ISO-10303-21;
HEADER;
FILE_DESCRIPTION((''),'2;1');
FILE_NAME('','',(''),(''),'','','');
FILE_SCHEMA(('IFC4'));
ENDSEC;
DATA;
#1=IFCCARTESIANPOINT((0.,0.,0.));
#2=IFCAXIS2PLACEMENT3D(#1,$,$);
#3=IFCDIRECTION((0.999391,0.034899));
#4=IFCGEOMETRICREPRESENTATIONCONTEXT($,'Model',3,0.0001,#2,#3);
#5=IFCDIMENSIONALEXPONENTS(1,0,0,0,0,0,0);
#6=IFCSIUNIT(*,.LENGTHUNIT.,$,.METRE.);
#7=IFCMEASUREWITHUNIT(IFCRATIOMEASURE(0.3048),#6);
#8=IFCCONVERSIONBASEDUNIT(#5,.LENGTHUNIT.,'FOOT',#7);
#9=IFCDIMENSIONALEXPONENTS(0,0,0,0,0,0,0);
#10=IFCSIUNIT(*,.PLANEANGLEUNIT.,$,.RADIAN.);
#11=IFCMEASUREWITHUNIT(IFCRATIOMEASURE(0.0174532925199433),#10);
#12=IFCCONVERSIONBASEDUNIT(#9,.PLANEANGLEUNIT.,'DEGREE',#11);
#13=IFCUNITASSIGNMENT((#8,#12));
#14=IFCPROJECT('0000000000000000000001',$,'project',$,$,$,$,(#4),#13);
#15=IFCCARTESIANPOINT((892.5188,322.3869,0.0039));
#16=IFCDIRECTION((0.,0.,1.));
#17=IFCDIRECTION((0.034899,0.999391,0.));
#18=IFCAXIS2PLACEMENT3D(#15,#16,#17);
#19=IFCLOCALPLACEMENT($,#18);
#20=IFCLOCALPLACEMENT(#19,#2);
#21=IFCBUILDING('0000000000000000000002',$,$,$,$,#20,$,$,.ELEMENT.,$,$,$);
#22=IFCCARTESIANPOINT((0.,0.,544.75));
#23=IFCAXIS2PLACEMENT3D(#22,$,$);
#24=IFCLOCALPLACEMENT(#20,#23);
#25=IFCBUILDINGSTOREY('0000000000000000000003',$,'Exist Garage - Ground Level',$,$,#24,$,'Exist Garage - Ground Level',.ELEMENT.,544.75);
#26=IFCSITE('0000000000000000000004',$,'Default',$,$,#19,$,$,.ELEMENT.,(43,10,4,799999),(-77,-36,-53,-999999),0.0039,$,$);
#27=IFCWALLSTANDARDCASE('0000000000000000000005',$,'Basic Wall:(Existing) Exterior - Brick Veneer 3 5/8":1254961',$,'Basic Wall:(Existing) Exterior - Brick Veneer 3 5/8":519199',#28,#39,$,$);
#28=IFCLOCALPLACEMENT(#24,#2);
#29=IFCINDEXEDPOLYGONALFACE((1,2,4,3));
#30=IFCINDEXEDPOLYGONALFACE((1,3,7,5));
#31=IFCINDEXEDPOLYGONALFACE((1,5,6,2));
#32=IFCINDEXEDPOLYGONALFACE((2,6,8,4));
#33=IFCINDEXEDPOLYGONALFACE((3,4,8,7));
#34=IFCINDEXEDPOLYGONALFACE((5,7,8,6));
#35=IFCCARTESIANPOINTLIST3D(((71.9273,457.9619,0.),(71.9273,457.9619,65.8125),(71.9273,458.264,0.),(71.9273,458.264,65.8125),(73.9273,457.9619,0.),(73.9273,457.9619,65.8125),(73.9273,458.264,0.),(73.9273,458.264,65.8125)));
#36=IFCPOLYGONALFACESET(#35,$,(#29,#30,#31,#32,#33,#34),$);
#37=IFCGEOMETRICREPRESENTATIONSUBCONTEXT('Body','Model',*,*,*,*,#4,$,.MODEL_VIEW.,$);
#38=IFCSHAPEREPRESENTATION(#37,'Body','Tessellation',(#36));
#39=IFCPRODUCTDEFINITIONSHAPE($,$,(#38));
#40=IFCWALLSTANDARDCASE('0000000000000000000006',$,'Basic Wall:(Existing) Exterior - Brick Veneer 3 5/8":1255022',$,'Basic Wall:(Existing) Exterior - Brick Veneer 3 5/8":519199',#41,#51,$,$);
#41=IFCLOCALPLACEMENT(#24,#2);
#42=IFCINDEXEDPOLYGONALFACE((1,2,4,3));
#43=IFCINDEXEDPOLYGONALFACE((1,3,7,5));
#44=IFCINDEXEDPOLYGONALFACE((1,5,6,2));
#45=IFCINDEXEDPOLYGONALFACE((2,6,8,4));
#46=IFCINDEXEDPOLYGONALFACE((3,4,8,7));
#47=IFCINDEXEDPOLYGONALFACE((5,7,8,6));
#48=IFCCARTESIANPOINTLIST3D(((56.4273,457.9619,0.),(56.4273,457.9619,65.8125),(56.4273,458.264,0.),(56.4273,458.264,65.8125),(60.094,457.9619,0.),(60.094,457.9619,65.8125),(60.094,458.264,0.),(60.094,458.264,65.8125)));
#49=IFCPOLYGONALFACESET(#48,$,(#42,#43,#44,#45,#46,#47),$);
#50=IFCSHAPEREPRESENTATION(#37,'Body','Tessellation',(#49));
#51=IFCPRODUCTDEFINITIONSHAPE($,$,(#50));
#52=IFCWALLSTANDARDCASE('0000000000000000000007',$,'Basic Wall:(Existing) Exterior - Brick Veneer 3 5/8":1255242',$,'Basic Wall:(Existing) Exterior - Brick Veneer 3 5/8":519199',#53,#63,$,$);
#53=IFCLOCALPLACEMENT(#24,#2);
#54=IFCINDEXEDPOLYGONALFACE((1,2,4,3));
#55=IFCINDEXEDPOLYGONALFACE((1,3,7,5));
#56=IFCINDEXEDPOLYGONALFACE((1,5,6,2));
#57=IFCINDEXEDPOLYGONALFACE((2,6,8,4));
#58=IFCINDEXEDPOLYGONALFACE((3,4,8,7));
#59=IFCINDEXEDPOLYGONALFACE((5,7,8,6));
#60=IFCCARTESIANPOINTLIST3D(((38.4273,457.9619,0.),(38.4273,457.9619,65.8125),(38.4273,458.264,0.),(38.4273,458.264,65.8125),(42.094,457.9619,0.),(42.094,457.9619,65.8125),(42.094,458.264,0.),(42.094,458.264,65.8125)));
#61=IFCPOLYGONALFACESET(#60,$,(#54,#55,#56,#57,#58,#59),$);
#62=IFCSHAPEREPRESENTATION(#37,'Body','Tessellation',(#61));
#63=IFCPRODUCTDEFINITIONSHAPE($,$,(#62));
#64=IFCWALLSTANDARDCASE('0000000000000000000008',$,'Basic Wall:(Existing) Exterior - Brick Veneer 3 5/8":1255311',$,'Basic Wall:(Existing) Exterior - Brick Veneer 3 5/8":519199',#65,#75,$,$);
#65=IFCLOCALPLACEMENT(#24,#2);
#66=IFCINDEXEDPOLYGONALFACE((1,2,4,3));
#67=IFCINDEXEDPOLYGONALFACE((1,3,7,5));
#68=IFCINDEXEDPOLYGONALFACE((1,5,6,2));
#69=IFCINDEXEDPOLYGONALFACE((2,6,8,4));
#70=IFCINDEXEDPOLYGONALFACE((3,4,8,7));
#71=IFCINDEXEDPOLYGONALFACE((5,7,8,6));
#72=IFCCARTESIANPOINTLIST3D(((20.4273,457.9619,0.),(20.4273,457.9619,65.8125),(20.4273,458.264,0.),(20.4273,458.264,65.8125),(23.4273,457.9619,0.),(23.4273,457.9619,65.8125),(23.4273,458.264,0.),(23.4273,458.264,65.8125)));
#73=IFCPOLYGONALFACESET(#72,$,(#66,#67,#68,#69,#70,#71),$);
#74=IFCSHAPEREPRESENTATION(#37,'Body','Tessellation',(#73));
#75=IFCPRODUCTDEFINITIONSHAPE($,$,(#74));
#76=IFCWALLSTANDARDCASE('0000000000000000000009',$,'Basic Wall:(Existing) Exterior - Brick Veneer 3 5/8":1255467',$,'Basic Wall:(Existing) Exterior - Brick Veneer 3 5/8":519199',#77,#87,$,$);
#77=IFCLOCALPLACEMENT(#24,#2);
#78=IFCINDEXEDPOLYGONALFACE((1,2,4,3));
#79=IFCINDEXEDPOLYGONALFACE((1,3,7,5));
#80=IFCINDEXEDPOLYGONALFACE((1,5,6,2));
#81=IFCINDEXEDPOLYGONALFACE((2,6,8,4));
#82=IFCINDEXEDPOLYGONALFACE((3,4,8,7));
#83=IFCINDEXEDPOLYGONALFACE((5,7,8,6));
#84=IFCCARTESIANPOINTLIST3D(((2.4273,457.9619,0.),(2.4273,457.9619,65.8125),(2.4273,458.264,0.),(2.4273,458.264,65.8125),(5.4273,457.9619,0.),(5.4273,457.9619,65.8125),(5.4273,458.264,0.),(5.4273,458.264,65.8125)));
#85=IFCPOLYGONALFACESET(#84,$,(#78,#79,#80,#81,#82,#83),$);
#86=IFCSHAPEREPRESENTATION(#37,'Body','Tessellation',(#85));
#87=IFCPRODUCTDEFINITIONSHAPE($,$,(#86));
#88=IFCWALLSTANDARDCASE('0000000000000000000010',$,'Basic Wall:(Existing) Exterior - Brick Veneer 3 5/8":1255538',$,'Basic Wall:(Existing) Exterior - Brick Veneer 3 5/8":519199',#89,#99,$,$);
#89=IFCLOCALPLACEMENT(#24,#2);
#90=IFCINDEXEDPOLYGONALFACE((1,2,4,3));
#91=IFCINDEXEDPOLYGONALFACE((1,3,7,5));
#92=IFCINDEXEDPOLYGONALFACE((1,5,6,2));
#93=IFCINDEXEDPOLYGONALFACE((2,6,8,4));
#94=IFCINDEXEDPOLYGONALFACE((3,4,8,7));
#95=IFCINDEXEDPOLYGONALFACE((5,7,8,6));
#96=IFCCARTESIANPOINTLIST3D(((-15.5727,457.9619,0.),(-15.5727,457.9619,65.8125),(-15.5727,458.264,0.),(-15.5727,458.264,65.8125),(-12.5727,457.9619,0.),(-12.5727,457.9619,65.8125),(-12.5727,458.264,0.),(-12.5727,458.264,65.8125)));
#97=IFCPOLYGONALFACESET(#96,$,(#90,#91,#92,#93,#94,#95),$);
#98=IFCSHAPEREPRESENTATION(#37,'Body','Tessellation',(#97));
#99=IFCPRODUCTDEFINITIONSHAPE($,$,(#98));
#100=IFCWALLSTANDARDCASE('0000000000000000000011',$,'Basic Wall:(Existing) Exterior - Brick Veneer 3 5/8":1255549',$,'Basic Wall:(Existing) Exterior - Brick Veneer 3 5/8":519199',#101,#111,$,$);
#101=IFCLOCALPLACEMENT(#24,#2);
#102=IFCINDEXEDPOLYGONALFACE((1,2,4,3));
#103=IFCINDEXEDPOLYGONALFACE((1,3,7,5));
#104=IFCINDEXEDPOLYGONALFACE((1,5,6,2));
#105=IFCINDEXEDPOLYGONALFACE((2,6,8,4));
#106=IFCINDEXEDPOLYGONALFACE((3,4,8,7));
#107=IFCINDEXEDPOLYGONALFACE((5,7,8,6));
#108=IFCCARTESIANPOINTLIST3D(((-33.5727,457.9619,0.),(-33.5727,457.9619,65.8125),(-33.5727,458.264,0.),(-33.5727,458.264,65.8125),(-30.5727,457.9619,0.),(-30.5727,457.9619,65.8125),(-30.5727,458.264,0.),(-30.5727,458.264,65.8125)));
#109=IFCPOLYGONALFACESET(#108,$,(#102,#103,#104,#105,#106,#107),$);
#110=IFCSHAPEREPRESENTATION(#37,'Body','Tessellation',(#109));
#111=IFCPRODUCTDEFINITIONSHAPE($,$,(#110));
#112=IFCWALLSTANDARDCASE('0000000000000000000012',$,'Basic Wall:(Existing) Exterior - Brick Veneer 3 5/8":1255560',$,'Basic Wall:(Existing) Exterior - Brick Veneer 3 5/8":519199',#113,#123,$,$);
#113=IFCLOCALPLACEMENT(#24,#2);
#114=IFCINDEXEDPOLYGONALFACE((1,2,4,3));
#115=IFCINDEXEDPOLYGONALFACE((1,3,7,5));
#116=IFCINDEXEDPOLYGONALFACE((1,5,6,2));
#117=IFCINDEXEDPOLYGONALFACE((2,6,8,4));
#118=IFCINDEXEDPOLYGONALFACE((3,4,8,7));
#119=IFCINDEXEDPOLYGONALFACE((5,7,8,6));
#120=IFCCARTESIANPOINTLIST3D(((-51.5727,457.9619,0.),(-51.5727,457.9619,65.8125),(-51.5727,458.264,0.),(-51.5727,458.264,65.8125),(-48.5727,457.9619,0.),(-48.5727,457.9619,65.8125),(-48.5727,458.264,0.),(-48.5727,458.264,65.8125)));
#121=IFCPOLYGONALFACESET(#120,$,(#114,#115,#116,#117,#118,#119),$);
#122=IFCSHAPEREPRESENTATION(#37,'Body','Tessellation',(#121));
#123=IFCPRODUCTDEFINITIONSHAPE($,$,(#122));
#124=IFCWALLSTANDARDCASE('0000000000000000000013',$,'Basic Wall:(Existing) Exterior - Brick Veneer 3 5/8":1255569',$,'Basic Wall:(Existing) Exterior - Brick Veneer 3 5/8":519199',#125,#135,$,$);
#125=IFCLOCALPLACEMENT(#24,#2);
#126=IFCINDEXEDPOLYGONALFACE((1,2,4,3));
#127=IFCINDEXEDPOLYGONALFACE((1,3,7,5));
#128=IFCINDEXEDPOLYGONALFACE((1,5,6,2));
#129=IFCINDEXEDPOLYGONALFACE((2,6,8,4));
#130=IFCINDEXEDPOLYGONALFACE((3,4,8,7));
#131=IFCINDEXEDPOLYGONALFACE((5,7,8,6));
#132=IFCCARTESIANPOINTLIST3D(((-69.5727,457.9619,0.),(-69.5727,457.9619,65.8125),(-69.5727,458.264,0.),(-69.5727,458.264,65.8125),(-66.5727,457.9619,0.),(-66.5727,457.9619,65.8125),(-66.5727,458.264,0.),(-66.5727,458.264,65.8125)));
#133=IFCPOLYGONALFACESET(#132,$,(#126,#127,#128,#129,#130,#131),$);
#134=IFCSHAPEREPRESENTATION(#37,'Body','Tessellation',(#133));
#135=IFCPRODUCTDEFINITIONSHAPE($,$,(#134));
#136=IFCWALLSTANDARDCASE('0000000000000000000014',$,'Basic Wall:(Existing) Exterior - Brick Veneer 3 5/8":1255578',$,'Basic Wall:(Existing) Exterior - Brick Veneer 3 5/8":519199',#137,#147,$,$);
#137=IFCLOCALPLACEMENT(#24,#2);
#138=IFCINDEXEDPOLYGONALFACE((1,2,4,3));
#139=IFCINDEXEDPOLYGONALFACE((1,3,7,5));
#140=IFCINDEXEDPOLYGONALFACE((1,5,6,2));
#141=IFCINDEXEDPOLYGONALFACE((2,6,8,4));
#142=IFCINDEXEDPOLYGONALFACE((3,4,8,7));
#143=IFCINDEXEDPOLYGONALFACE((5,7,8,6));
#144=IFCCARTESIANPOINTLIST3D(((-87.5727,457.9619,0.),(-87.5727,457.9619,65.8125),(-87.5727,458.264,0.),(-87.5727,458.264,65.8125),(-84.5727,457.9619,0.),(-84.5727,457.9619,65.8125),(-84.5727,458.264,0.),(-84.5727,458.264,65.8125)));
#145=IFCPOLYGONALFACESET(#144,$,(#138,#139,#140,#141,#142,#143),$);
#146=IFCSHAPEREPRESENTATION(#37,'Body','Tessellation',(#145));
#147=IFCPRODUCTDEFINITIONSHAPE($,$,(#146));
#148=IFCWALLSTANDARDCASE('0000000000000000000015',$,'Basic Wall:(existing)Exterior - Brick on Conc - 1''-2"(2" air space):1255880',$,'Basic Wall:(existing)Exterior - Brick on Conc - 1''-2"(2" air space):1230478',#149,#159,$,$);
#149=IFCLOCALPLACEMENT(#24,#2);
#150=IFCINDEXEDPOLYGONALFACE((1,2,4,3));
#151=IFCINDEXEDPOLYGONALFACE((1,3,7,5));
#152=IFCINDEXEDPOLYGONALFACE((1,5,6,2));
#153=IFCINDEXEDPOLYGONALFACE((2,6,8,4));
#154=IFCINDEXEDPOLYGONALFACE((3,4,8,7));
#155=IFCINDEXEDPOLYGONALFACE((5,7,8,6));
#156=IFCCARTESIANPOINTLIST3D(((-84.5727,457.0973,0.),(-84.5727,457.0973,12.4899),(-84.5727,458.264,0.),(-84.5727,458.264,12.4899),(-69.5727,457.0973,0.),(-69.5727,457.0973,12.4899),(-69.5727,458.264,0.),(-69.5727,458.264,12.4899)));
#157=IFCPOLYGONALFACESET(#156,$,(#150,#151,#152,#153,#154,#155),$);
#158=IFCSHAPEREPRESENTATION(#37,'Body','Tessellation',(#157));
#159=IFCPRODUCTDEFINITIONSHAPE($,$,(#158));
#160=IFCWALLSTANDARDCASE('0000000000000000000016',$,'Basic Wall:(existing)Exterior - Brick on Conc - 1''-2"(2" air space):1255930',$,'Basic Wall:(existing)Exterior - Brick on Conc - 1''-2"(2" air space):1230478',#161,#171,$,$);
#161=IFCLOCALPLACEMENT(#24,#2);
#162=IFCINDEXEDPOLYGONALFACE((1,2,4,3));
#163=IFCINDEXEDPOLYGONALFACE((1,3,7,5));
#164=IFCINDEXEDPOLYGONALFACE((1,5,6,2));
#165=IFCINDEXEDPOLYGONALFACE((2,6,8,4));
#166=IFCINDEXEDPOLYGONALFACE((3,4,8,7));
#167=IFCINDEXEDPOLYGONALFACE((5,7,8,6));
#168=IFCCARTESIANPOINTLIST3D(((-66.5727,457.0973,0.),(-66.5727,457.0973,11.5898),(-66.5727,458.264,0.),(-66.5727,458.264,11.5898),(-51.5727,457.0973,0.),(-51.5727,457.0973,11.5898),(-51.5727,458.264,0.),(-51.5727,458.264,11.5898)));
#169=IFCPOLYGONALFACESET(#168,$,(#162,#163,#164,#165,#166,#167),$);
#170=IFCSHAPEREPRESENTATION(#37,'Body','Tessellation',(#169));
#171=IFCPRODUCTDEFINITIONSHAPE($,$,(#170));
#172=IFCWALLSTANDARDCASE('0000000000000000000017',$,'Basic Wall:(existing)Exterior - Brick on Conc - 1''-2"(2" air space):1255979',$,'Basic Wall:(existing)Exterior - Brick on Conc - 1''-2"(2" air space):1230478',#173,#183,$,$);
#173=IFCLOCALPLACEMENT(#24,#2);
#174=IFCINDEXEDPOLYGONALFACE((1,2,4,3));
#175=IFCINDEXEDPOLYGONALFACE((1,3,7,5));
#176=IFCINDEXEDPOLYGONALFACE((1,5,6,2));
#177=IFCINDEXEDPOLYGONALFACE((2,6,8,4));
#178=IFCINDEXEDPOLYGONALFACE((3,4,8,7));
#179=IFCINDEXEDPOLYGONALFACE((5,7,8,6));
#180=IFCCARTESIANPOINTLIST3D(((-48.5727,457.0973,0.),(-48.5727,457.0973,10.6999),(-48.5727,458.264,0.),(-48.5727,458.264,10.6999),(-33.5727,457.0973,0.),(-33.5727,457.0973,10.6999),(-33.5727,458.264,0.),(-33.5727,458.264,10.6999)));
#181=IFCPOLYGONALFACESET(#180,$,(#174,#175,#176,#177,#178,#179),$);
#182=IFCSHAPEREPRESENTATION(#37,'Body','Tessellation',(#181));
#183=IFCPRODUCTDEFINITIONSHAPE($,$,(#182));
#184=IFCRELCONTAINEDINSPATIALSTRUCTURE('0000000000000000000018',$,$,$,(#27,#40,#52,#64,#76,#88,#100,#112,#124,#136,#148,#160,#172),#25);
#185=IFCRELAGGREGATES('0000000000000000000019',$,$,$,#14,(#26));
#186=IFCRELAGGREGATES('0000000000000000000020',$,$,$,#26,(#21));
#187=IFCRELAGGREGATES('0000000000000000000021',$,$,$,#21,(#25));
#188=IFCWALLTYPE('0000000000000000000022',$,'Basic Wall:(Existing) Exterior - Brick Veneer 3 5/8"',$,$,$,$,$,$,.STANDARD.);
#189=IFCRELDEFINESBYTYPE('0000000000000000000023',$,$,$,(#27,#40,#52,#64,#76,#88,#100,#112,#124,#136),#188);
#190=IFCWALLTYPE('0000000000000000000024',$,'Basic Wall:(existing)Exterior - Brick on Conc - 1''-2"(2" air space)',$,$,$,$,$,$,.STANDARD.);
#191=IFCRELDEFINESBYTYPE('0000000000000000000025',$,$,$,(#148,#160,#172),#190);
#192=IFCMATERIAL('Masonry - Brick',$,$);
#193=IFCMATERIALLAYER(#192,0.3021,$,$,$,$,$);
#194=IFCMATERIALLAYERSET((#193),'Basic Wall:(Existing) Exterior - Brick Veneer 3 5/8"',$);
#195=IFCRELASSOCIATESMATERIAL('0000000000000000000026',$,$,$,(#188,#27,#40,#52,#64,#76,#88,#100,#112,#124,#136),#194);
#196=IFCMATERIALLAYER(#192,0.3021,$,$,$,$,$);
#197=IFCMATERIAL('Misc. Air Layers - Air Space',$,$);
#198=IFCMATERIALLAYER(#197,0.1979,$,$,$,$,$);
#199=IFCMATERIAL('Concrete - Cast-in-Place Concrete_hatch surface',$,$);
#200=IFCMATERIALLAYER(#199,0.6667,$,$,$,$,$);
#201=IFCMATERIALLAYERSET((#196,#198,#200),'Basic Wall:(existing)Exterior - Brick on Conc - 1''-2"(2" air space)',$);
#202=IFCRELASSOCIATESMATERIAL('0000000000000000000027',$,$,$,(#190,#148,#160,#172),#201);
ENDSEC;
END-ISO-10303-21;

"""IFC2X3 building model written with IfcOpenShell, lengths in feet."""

from ifc_helpers import new_model, entity, si_unit, converted_unit, direction, frame, frame_2d, origin, place, context, subcontext, project, spatial, rectangle, extrude, material, layer, layer_set, layer_usage, type_object, element, save


model = new_model("IFC2X3")

# Units and contexts
model_context = context("Model", 3, precision=0.0001, world=origin(), true_north=direction((0.999391, 0.034899)))
body_context = subcontext(model_context, "Body", "Model", "MODEL_VIEW")
ifc_project = project(units=[converted_unit("LENGTHUNIT", "FOOT", entity("IfcRatioMeasure", 0.3048), si_unit("LENGTHUNIT", "METRE"), dimensions=[1, 0, 0, 0, 0, 0, 0]), converted_unit("PLANEANGLEUNIT", "DEGREE", entity("IfcRatioMeasure", 0.0174532925199433), si_unit("PLANEANGLEUNIT", "RADIAN"), dimensions=[0, 0, 0, 0, 0, 0, 0])], contexts=[model_context])

# Site, building, storey
site_placement = place(None, frame((892.5188, 322.3869, 0.0039), z_axis=(0.0, 0.0, 1.0), x_axis=(0.034899, 0.999391, 0.0)))
site = spatial("IfcSite", under=ifc_project, at=site_placement, Name="Default", CompositionType="ELEMENT", RefLatitude=(43, 10, 4, 799999), RefLongitude=(-77, -36, -53, -999999), RefElevation=0.0039)
building_placement = place(site_placement, origin())
building = spatial("IfcBuilding", under=site, at=building_placement, CompositionType="ELEMENT")
storey_placement = place(building_placement, frame((0.0, 0.0, 544.75)))
storey = spatial("IfcBuildingStorey", under=building, at=storey_placement, Name="Exist Garage - Ground Level", LongName="Exist Garage - Ground Level", CompositionType="ELEMENT", Elevation=544.75)

# Walls
ifc_material_1 = material(Name="Masonry - Brick")
ifc_layer_1 = layer(ifc_material_1, 0.3021)
ifc_layer_set_1 = layer_set([ifc_layer_1], Name="Basic Wall:(Existing) Exterior - Brick Veneer 3 5/8\"")
ifc_layer_usage_1 = layer_usage(ifc_layer_set_1, "AXIS2", "NEGATIVE", 0.151)
wall_type_1 = type_object("IfcWallType", Name="Basic Wall:(Existing) Exterior - Brick Veneer 3 5/8\"", PredefinedType="STANDARD", material=ifc_layer_set_1)
wall_1_placement = place(storey_placement, frame((71.9273, 458.1129, 0.0)))
element("IfcWallStandardCase", 1, at=wall_1_placement, inside=storey, type_object=wall_type_1, material=ifc_layer_usage_1, Name="Basic Wall:(Existing) Exterior - Brick Veneer 3 5/8\":1254961", ObjectType="Basic Wall:(Existing) Exterior - Brick Veneer 3 5/8\":519199", context=body_context, shape_type="SweptSolid", body=[
    extrude(rectangle(XDim=2.0, YDim=0.3021, at=frame_2d((1.0, 0.0), x_axis=(-1.0, 0.0))), origin(), (0.0, 0.0, 1.0), 65.8125),
])
ifc_layer_usage_2 = layer_usage(ifc_layer_set_1, "AXIS2", "NEGATIVE", 0.151)
wall_2_placement = place(storey_placement, frame((56.4273, 458.1129, 0.0)))
element("IfcWallStandardCase", 2, at=wall_2_placement, inside=storey, type_object=wall_type_1, material=ifc_layer_usage_2, Name="Basic Wall:(Existing) Exterior - Brick Veneer 3 5/8\":1255022", ObjectType="Basic Wall:(Existing) Exterior - Brick Veneer 3 5/8\":519199", context=body_context, shape_type="SweptSolid", body=[
    extrude(rectangle(XDim=3.6667, YDim=0.3021, at=frame_2d((1.8334, 0.0), x_axis=(-1.0, 0.0))), origin(), (0.0, 0.0, 1.0), 65.8125),
])
ifc_layer_usage_3 = layer_usage(ifc_layer_set_1, "AXIS2", "NEGATIVE", 0.151)
wall_3_placement = place(storey_placement, frame((38.4273, 458.1129, 0.0)))
element("IfcWallStandardCase", 3, at=wall_3_placement, inside=storey, type_object=wall_type_1, material=ifc_layer_usage_3, Name="Basic Wall:(Existing) Exterior - Brick Veneer 3 5/8\":1255242", ObjectType="Basic Wall:(Existing) Exterior - Brick Veneer 3 5/8\":519199", context=body_context, shape_type="SweptSolid", body=[
    extrude(rectangle(XDim=3.6667, YDim=0.3021, at=frame_2d((1.8334, 0.0), x_axis=(-1.0, 0.0))), origin(), (0.0, 0.0, 1.0), 65.8125),
])
ifc_layer_usage_4 = layer_usage(ifc_layer_set_1, "AXIS2", "NEGATIVE", 0.151)
wall_4_placement = place(storey_placement, frame((20.4273, 458.1129, 0.0)))
element("IfcWallStandardCase", 4, at=wall_4_placement, inside=storey, type_object=wall_type_1, material=ifc_layer_usage_4, Name="Basic Wall:(Existing) Exterior - Brick Veneer 3 5/8\":1255311", ObjectType="Basic Wall:(Existing) Exterior - Brick Veneer 3 5/8\":519199", context=body_context, shape_type="SweptSolid", body=[
    extrude(rectangle(XDim=3.0, YDim=0.3021, at=frame_2d((1.5, 0.0), x_axis=(-1.0, 0.0))), origin(), (0.0, 0.0, 1.0), 65.8125),
])
ifc_layer_usage_5 = layer_usage(ifc_layer_set_1, "AXIS2", "NEGATIVE", 0.151)
wall_5_placement = place(storey_placement, frame((2.4273, 458.1129, 0.0)))
element("IfcWallStandardCase", 5, at=wall_5_placement, inside=storey, type_object=wall_type_1, material=ifc_layer_usage_5, Name="Basic Wall:(Existing) Exterior - Brick Veneer 3 5/8\":1255467", ObjectType="Basic Wall:(Existing) Exterior - Brick Veneer 3 5/8\":519199", context=body_context, shape_type="SweptSolid", body=[
    extrude(rectangle(XDim=3.0, YDim=0.3021, at=frame_2d((1.5, 0.0), x_axis=(-1.0, 0.0))), origin(), (0.0, 0.0, 1.0), 65.8125),
])
ifc_layer_usage_6 = layer_usage(ifc_layer_set_1, "AXIS2", "NEGATIVE", 0.151)
wall_6_placement = place(storey_placement, frame((-15.5727, 458.1129, 0.0)))
element("IfcWallStandardCase", 6, at=wall_6_placement, inside=storey, type_object=wall_type_1, material=ifc_layer_usage_6, Name="Basic Wall:(Existing) Exterior - Brick Veneer 3 5/8\":1255538", ObjectType="Basic Wall:(Existing) Exterior - Brick Veneer 3 5/8\":519199", context=body_context, shape_type="SweptSolid", body=[
    extrude(rectangle(XDim=3.0, YDim=0.3021, at=frame_2d((1.5, 0.0), x_axis=(-1.0, 0.0))), origin(), (0.0, 0.0, 1.0), 65.8125),
])
ifc_layer_usage_7 = layer_usage(ifc_layer_set_1, "AXIS2", "NEGATIVE", 0.151)
wall_7_placement = place(storey_placement, frame((-33.5727, 458.1129, 0.0)))
element("IfcWallStandardCase", 7, at=wall_7_placement, inside=storey, type_object=wall_type_1, material=ifc_layer_usage_7, Name="Basic Wall:(Existing) Exterior - Brick Veneer 3 5/8\":1255549", ObjectType="Basic Wall:(Existing) Exterior - Brick Veneer 3 5/8\":519199", context=body_context, shape_type="SweptSolid", body=[
    extrude(rectangle(XDim=3.0, YDim=0.3021, at=frame_2d((1.5, 0.0), x_axis=(-1.0, 0.0))), origin(), (0.0, 0.0, 1.0), 65.8125),
])
ifc_layer_usage_8 = layer_usage(ifc_layer_set_1, "AXIS2", "NEGATIVE", 0.151)
wall_8_placement = place(storey_placement, frame((-51.5727, 458.1129, 0.0)))
element("IfcWallStandardCase", 8, at=wall_8_placement, inside=storey, type_object=wall_type_1, material=ifc_layer_usage_8, Name="Basic Wall:(Existing) Exterior - Brick Veneer 3 5/8\":1255560", ObjectType="Basic Wall:(Existing) Exterior - Brick Veneer 3 5/8\":519199", context=body_context, shape_type="SweptSolid", body=[
    extrude(rectangle(XDim=3.0, YDim=0.3021, at=frame_2d((1.5, 0.0), x_axis=(-1.0, 0.0))), origin(), (0.0, 0.0, 1.0), 65.8125),
])
ifc_layer_usage_9 = layer_usage(ifc_layer_set_1, "AXIS2", "NEGATIVE", 0.151)
wall_9_placement = place(storey_placement, frame((-69.5727, 458.1129, 0.0)))
element("IfcWallStandardCase", 9, at=wall_9_placement, inside=storey, type_object=wall_type_1, material=ifc_layer_usage_9, Name="Basic Wall:(Existing) Exterior - Brick Veneer 3 5/8\":1255569", ObjectType="Basic Wall:(Existing) Exterior - Brick Veneer 3 5/8\":519199", context=body_context, shape_type="SweptSolid", body=[
    extrude(rectangle(XDim=3.0, YDim=0.3021, at=frame_2d((1.5, 0.0), x_axis=(-1.0, 0.0))), origin(), (0.0, 0.0, 1.0), 65.8125),
])
ifc_layer_usage_10 = layer_usage(ifc_layer_set_1, "AXIS2", "NEGATIVE", 0.151)
wall_10_placement = place(storey_placement, frame((-87.5727, 458.1129, 0.0)))
element("IfcWallStandardCase", 10, at=wall_10_placement, inside=storey, type_object=wall_type_1, material=ifc_layer_usage_10, Name="Basic Wall:(Existing) Exterior - Brick Veneer 3 5/8\":1255578", ObjectType="Basic Wall:(Existing) Exterior - Brick Veneer 3 5/8\":519199", context=body_context, shape_type="SweptSolid", body=[
    extrude(rectangle(XDim=3.0, YDim=0.3021, at=frame_2d((1.5, 0.0), x_axis=(-1.0, 0.0))), origin(), (0.0, 0.0, 1.0), 65.8125),
])
ifc_layer_2 = layer(ifc_material_1, 0.3021)
ifc_material_2 = material(Name="Misc. Air Layers - Air Space")
ifc_layer_3 = layer(ifc_material_2, 0.1979)
ifc_material_3 = material(Name="Concrete - Cast-in-Place Concrete_hatch surface")
ifc_layer_4 = layer(ifc_material_3, 0.6667)
ifc_layer_set_2 = layer_set([ifc_layer_2, ifc_layer_3, ifc_layer_4], Name="Basic Wall:(existing)Exterior - Brick on Conc - 1'-2\"(2\" air space)")
ifc_layer_usage_11 = layer_usage(ifc_layer_set_2, "AXIS2", "POSITIVE", -0.5833)
wall_type_2 = type_object("IfcWallType", Name="Basic Wall:(existing)Exterior - Brick on Conc - 1'-2\"(2\" air space)", PredefinedType="STANDARD", material=ifc_layer_set_2)
wall_11_placement = place(storey_placement, frame((-69.5727, 457.6806, 0.0), z_axis=(0.0, 0.0, 1.0), x_axis=(-1.0, 0.0, 0.0)))
element("IfcWallStandardCase", 11, at=wall_11_placement, inside=storey, type_object=wall_type_2, material=ifc_layer_usage_11, Name="Basic Wall:(existing)Exterior - Brick on Conc - 1'-2\"(2\" air space):1255880", ObjectType="Basic Wall:(existing)Exterior - Brick on Conc - 1'-2\"(2\" air space):1230478", context=body_context, shape_type="SweptSolid", body=[
    extrude(rectangle(XDim=15.0, YDim=1.1667, at=frame_2d((7.5, 0.0), x_axis=(-1.0, 0.0))), origin(), (0.0, 0.0, 1.0), 12.4899),
])
ifc_layer_usage_12 = layer_usage(ifc_layer_set_2, "AXIS2", "POSITIVE", -0.5833)
wall_12_placement = place(storey_placement, frame((-51.5727, 457.6806, 0.0), z_axis=(0.0, 0.0, 1.0), x_axis=(-1.0, 0.0, 0.0)))
element("IfcWallStandardCase", 12, at=wall_12_placement, inside=storey, type_object=wall_type_2, material=ifc_layer_usage_12, Name="Basic Wall:(existing)Exterior - Brick on Conc - 1'-2\"(2\" air space):1255930", ObjectType="Basic Wall:(existing)Exterior - Brick on Conc - 1'-2\"(2\" air space):1230478", context=body_context, shape_type="SweptSolid", body=[
    extrude(rectangle(XDim=15.0, YDim=1.1667, at=frame_2d((7.5, 0.0), x_axis=(-1.0, 0.0))), origin(), (0.0, 0.0, 1.0), 11.5898),
])
ifc_layer_usage_13 = layer_usage(ifc_layer_set_2, "AXIS2", "POSITIVE", -0.5833)
wall_13_placement = place(storey_placement, frame((-33.5727, 457.6806, 0.0), z_axis=(0.0, 0.0, 1.0), x_axis=(-1.0, 0.0, 0.0)))
element("IfcWallStandardCase", 13, at=wall_13_placement, inside=storey, type_object=wall_type_2, material=ifc_layer_usage_13, Name="Basic Wall:(existing)Exterior - Brick on Conc - 1'-2\"(2\" air space):1255979", ObjectType="Basic Wall:(existing)Exterior - Brick on Conc - 1'-2\"(2\" air space):1230478", context=body_context, shape_type="SweptSolid", body=[
    extrude(rectangle(XDim=15.0, YDim=1.1667, at=frame_2d((7.5, 0.0), x_axis=(-1.0, 0.0))), origin(), (0.0, 0.0, 1.0), 10.6999),
])

save(model, "model.ifc")
